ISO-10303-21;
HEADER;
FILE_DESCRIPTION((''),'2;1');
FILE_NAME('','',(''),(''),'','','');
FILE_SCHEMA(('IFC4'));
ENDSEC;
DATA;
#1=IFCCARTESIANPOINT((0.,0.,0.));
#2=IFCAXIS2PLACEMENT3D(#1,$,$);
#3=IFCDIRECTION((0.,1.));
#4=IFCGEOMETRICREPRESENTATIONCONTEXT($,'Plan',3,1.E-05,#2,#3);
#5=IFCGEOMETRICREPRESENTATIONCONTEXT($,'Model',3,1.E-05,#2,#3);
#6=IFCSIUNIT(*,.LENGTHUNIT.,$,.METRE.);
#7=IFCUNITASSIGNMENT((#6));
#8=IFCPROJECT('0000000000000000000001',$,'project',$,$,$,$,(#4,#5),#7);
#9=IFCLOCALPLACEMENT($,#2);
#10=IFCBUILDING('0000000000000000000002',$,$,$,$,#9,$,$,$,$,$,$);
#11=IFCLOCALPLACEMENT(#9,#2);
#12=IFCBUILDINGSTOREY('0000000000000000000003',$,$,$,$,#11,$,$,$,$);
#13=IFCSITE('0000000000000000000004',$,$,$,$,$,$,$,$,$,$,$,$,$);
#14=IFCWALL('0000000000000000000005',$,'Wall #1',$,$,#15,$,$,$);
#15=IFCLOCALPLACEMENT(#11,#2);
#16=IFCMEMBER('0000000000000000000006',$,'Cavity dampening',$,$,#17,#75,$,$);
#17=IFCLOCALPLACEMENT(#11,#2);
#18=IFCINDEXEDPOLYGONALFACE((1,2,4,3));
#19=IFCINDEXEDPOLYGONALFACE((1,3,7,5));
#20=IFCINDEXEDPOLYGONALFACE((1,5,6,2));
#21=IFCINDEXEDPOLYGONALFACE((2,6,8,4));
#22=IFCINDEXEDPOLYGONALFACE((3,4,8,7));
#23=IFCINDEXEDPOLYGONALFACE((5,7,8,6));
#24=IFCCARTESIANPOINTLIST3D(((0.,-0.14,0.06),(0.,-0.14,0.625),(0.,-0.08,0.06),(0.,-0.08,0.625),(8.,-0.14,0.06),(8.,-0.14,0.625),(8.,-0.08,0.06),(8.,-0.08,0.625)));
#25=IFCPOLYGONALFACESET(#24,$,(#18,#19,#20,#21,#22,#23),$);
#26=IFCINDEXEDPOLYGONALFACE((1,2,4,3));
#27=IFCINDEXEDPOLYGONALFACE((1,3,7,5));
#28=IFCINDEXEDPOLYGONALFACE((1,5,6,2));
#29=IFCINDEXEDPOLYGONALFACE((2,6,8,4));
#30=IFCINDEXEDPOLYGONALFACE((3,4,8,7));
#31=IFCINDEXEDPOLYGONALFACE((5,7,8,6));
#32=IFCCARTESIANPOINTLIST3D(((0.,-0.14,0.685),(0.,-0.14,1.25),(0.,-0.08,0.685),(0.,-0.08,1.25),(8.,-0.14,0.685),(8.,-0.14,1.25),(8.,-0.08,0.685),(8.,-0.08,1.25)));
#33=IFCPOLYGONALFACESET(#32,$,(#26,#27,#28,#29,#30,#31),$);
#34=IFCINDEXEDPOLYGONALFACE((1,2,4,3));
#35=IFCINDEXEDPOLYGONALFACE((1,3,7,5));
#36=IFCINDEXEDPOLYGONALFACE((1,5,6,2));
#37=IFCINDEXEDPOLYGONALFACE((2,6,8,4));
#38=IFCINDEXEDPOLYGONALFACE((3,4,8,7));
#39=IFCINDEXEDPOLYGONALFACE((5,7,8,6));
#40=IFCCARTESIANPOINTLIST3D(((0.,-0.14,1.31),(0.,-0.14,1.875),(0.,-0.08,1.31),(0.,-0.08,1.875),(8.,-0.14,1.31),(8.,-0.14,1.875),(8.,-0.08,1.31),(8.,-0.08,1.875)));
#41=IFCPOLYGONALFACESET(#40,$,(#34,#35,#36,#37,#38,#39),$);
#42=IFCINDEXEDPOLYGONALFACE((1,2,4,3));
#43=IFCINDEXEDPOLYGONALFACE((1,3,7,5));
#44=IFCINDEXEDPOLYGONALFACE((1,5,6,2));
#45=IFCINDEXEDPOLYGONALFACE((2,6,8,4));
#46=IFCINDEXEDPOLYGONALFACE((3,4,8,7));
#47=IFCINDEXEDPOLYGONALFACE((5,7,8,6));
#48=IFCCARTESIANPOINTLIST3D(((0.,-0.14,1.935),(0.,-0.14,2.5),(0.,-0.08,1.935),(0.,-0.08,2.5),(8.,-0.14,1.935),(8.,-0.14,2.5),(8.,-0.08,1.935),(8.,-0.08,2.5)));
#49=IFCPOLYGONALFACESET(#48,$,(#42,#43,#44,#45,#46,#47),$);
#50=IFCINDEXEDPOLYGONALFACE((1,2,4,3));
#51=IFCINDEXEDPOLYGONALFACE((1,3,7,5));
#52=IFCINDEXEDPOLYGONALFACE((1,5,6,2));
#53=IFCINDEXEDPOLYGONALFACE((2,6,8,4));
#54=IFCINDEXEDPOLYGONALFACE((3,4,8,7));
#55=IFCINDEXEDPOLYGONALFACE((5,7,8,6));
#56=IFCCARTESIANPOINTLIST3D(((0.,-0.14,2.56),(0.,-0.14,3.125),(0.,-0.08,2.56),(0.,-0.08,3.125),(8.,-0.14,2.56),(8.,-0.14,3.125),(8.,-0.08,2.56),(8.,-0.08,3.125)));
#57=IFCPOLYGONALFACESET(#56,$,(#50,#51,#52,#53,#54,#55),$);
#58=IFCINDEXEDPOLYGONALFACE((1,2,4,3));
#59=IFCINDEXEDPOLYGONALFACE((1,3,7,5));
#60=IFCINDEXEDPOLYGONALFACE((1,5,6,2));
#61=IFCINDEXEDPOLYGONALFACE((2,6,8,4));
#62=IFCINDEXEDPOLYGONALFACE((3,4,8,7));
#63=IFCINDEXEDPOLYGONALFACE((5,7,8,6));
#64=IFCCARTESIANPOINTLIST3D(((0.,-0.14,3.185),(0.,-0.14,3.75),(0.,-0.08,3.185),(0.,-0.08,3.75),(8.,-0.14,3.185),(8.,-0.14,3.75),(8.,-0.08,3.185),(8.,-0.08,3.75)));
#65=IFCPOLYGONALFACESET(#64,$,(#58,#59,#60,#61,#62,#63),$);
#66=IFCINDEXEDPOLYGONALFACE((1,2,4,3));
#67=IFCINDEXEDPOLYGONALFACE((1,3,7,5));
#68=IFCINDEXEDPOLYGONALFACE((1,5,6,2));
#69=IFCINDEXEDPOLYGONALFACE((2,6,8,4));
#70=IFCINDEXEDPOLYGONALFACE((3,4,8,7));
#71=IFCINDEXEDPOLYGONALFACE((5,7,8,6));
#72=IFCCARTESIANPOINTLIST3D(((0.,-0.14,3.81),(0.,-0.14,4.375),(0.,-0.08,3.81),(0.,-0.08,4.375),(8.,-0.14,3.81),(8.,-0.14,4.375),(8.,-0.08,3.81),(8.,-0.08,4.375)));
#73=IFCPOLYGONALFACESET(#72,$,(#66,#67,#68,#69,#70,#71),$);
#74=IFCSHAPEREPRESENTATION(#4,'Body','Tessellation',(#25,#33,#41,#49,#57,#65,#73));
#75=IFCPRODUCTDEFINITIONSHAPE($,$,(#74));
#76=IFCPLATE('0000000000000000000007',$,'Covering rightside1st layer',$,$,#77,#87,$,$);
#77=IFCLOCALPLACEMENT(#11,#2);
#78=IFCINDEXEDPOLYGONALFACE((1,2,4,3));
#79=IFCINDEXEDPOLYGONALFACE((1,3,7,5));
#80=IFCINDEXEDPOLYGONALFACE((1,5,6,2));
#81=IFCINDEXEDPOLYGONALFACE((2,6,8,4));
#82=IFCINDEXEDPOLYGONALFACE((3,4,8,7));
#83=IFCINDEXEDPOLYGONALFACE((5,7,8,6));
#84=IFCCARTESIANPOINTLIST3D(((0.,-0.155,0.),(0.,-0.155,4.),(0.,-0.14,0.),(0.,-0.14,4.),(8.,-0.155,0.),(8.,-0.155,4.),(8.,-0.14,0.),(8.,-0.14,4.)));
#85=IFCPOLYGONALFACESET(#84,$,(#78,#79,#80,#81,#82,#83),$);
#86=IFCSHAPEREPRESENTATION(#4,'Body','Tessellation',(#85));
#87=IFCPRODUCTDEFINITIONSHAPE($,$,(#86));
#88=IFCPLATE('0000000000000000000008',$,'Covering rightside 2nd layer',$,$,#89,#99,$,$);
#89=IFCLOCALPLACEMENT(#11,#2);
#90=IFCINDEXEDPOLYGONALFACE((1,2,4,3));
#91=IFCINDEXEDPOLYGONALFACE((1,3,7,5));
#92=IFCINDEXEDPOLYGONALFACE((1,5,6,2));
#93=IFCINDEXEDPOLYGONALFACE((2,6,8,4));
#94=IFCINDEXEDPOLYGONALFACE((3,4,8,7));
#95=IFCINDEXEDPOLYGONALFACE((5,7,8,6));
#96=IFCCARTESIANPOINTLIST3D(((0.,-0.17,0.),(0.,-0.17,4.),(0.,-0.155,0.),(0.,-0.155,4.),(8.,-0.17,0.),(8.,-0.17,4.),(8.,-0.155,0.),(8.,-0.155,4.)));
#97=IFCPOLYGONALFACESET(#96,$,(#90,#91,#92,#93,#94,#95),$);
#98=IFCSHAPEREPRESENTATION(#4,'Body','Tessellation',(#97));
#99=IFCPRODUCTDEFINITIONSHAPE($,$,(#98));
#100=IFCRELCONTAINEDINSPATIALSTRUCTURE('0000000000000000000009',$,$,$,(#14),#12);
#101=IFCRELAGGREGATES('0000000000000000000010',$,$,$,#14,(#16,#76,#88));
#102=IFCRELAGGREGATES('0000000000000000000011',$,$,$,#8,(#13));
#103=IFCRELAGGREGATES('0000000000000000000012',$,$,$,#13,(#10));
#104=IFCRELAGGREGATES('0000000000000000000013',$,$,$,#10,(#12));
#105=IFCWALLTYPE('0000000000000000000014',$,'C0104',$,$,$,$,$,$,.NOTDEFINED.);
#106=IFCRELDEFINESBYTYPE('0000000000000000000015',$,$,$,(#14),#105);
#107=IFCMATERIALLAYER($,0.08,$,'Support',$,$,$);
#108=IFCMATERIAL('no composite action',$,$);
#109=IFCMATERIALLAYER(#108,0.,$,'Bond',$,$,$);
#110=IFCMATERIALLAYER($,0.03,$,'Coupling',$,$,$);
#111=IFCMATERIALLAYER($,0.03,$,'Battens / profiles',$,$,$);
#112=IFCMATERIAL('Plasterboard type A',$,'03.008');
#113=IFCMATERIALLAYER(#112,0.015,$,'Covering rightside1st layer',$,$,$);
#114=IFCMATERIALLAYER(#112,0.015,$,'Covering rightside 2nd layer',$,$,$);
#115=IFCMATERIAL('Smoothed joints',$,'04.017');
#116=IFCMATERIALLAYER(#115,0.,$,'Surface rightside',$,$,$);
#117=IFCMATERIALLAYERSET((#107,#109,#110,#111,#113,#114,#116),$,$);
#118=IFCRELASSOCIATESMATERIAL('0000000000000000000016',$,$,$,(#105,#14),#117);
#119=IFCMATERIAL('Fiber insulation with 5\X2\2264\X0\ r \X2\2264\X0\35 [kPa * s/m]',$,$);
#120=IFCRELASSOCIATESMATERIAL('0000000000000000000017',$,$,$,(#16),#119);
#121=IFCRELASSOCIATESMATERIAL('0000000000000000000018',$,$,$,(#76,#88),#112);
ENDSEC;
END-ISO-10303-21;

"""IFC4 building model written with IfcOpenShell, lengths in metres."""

from ifc_helpers import new_model, si_unit, direction, frame, frame_2d, origin, place, context, project, spatial, rectangle, extrude, material, layer, layer_set, type_object, element, aggregate, save


model = new_model("IFC4")

# Units and contexts
plan_context = context("Plan", 3, precision=1e-05, world=origin(), true_north=direction((0.0, 1.0)))
model_context = context("Model", 3, precision=1e-05, world=origin(), true_north=direction((0.0, 1.0)))
ifc_project = project(units=[si_unit("LENGTHUNIT", "METRE")], contexts=[plan_context, model_context])

# Site, building, storey
site = spatial("IfcSite", under=ifc_project)
building_placement = place(None, origin())
building = spatial("IfcBuilding", under=site, at=building_placement)
storey_placement = place(building_placement, origin())
storey = spatial("IfcBuildingStorey", under=building, at=storey_placement)

# Wall, member, plates
ifc_layer_1 = layer(None, 0.08, Name="Support")
ifc_material_1 = material(Name="no composite action")
ifc_layer_2 = layer(ifc_material_1, 0.0, Name="Bond")
ifc_layer_3 = layer(None, 0.03, Name="Coupling")
ifc_layer_4 = layer(None, 0.03, Name="Battens / profiles")
ifc_material_2 = material(Name="Plasterboard type A", Category="03.008")
ifc_layer_5 = layer(ifc_material_2, 0.015, Name="Covering rightside1st layer")
ifc_layer_6 = layer(ifc_material_2, 0.015, Name="Covering rightside 2nd layer")
ifc_material_3 = material(Name="Smoothed joints", Category="04.017")
ifc_layer_7 = layer(ifc_material_3, 0.0, Name="Surface rightside")
ifc_layer_set = layer_set([ifc_layer_1, ifc_layer_2, ifc_layer_3, ifc_layer_4, ifc_layer_5, ifc_layer_6, ifc_layer_7])
wall_type = type_object("IfcWallType", Name="C0104", PredefinedType="NOTDEFINED", material=ifc_layer_set)
wall_placement = place(None, frame((0.0, 0.0, 0.0), z_axis=(0.0, -1.0, 0.0), x_axis=(1.0, 0.0, 0.0)))
wall = element("IfcWall", 1, at=wall_placement, inside=storey, type_object=wall_type, material=ifc_layer_set, Name="Wall #1")
ifc_material_4 = material(Name="Fiber insulation with 5≤ r ≤35 [kPa * s/m]")
member_1_placement = place(wall_placement, origin())
member_1 = element("IfcMember", 2, at=member_1_placement, material=ifc_material_4, Name="Cavity dampening", context=plan_context, shape_type="SweptSolid", body=[
    extrude(rectangle(XDim=0.565, YDim=0.06, at=frame_2d((0.2825, 0.03), x_axis=(1.0, 0.0))), frame((0.0, 0.06, 0.08), z_axis=(1.0, 0.0, 0.0), x_axis=(0.0, 1.0, 0.0)), (0.0, 0.0, 1.0), 8.0),
    extrude(rectangle(XDim=0.565, YDim=0.06, at=frame_2d((0.2825, 0.03), x_axis=(1.0, 0.0))), frame((0.0, 0.685, 0.08), z_axis=(1.0, 0.0, 0.0), x_axis=(0.0, 1.0, 0.0)), (0.0, 0.0, 1.0), 8.0),
    extrude(rectangle(XDim=0.565, YDim=0.06, at=frame_2d((0.2825, 0.03), x_axis=(1.0, 0.0))), frame((0.0, 1.31, 0.08), z_axis=(1.0, 0.0, 0.0), x_axis=(0.0, 1.0, 0.0)), (0.0, 0.0, 1.0), 8.0),
    extrude(rectangle(XDim=0.565, YDim=0.06, at=frame_2d((0.2825, 0.03), x_axis=(1.0, 0.0))), frame((0.0, 1.935, 0.08), z_axis=(1.0, 0.0, 0.0), x_axis=(0.0, 1.0, 0.0)), (0.0, 0.0, 1.0), 8.0),
    extrude(rectangle(XDim=0.565, YDim=0.06, at=frame_2d((0.2825, 0.03), x_axis=(1.0, 0.0))), frame((0.0, 2.56, 0.08), z_axis=(1.0, 0.0, 0.0), x_axis=(0.0, 1.0, 0.0)), (0.0, 0.0, 1.0), 8.0),
    extrude(rectangle(XDim=0.565, YDim=0.06, at=frame_2d((0.2825, 0.03), x_axis=(1.0, 0.0))), frame((0.0, 3.185, 0.08), z_axis=(1.0, 0.0, 0.0), x_axis=(0.0, 1.0, 0.0)), (0.0, 0.0, 1.0), 8.0),
    extrude(rectangle(XDim=0.565, YDim=0.06, at=frame_2d((0.2825, 0.03), x_axis=(1.0, 0.0))), frame((0.0, 3.81, 0.08), z_axis=(1.0, 0.0, 0.0), x_axis=(0.0, 1.0, 0.0)), (0.0, 0.0, 1.0), 8.0),
])
plate_1_placement = place(wall_placement, origin())
plate_1 = element("IfcPlate", 3, at=plate_1_placement, material=ifc_material_2, Name="Covering rightside1st layer", context=plan_context, shape_type="SweptSolid", body=[
    extrude(rectangle(XDim=8.0, YDim=4.0, at=frame_2d((4.0, 2.0), x_axis=(1.0, 0.0))), frame((0.0, 0.0, 0.14), z_axis=(0.0, 0.0, 1.0), x_axis=(1.0, 0.0, 0.0)), (0.0, 0.0, 1.0), 0.015),
])
plate_2_placement = place(wall_placement, origin())
plate_2 = element("IfcPlate", 4, at=plate_2_placement, material=ifc_material_2, Name="Covering rightside 2nd layer", context=plan_context, shape_type="SweptSolid", body=[
    extrude(rectangle(XDim=8.0, YDim=4.0, at=frame_2d((4.0, 2.0), x_axis=(1.0, 0.0))), frame((0.0, 0.0, 0.155), z_axis=(0.0, 0.0, 1.0), x_axis=(1.0, 0.0, 0.0)), (0.0, 0.0, 1.0), 0.015),
])
aggregate(wall, [member_1, plate_1, plate_2])

save(model, "model.ifc")
